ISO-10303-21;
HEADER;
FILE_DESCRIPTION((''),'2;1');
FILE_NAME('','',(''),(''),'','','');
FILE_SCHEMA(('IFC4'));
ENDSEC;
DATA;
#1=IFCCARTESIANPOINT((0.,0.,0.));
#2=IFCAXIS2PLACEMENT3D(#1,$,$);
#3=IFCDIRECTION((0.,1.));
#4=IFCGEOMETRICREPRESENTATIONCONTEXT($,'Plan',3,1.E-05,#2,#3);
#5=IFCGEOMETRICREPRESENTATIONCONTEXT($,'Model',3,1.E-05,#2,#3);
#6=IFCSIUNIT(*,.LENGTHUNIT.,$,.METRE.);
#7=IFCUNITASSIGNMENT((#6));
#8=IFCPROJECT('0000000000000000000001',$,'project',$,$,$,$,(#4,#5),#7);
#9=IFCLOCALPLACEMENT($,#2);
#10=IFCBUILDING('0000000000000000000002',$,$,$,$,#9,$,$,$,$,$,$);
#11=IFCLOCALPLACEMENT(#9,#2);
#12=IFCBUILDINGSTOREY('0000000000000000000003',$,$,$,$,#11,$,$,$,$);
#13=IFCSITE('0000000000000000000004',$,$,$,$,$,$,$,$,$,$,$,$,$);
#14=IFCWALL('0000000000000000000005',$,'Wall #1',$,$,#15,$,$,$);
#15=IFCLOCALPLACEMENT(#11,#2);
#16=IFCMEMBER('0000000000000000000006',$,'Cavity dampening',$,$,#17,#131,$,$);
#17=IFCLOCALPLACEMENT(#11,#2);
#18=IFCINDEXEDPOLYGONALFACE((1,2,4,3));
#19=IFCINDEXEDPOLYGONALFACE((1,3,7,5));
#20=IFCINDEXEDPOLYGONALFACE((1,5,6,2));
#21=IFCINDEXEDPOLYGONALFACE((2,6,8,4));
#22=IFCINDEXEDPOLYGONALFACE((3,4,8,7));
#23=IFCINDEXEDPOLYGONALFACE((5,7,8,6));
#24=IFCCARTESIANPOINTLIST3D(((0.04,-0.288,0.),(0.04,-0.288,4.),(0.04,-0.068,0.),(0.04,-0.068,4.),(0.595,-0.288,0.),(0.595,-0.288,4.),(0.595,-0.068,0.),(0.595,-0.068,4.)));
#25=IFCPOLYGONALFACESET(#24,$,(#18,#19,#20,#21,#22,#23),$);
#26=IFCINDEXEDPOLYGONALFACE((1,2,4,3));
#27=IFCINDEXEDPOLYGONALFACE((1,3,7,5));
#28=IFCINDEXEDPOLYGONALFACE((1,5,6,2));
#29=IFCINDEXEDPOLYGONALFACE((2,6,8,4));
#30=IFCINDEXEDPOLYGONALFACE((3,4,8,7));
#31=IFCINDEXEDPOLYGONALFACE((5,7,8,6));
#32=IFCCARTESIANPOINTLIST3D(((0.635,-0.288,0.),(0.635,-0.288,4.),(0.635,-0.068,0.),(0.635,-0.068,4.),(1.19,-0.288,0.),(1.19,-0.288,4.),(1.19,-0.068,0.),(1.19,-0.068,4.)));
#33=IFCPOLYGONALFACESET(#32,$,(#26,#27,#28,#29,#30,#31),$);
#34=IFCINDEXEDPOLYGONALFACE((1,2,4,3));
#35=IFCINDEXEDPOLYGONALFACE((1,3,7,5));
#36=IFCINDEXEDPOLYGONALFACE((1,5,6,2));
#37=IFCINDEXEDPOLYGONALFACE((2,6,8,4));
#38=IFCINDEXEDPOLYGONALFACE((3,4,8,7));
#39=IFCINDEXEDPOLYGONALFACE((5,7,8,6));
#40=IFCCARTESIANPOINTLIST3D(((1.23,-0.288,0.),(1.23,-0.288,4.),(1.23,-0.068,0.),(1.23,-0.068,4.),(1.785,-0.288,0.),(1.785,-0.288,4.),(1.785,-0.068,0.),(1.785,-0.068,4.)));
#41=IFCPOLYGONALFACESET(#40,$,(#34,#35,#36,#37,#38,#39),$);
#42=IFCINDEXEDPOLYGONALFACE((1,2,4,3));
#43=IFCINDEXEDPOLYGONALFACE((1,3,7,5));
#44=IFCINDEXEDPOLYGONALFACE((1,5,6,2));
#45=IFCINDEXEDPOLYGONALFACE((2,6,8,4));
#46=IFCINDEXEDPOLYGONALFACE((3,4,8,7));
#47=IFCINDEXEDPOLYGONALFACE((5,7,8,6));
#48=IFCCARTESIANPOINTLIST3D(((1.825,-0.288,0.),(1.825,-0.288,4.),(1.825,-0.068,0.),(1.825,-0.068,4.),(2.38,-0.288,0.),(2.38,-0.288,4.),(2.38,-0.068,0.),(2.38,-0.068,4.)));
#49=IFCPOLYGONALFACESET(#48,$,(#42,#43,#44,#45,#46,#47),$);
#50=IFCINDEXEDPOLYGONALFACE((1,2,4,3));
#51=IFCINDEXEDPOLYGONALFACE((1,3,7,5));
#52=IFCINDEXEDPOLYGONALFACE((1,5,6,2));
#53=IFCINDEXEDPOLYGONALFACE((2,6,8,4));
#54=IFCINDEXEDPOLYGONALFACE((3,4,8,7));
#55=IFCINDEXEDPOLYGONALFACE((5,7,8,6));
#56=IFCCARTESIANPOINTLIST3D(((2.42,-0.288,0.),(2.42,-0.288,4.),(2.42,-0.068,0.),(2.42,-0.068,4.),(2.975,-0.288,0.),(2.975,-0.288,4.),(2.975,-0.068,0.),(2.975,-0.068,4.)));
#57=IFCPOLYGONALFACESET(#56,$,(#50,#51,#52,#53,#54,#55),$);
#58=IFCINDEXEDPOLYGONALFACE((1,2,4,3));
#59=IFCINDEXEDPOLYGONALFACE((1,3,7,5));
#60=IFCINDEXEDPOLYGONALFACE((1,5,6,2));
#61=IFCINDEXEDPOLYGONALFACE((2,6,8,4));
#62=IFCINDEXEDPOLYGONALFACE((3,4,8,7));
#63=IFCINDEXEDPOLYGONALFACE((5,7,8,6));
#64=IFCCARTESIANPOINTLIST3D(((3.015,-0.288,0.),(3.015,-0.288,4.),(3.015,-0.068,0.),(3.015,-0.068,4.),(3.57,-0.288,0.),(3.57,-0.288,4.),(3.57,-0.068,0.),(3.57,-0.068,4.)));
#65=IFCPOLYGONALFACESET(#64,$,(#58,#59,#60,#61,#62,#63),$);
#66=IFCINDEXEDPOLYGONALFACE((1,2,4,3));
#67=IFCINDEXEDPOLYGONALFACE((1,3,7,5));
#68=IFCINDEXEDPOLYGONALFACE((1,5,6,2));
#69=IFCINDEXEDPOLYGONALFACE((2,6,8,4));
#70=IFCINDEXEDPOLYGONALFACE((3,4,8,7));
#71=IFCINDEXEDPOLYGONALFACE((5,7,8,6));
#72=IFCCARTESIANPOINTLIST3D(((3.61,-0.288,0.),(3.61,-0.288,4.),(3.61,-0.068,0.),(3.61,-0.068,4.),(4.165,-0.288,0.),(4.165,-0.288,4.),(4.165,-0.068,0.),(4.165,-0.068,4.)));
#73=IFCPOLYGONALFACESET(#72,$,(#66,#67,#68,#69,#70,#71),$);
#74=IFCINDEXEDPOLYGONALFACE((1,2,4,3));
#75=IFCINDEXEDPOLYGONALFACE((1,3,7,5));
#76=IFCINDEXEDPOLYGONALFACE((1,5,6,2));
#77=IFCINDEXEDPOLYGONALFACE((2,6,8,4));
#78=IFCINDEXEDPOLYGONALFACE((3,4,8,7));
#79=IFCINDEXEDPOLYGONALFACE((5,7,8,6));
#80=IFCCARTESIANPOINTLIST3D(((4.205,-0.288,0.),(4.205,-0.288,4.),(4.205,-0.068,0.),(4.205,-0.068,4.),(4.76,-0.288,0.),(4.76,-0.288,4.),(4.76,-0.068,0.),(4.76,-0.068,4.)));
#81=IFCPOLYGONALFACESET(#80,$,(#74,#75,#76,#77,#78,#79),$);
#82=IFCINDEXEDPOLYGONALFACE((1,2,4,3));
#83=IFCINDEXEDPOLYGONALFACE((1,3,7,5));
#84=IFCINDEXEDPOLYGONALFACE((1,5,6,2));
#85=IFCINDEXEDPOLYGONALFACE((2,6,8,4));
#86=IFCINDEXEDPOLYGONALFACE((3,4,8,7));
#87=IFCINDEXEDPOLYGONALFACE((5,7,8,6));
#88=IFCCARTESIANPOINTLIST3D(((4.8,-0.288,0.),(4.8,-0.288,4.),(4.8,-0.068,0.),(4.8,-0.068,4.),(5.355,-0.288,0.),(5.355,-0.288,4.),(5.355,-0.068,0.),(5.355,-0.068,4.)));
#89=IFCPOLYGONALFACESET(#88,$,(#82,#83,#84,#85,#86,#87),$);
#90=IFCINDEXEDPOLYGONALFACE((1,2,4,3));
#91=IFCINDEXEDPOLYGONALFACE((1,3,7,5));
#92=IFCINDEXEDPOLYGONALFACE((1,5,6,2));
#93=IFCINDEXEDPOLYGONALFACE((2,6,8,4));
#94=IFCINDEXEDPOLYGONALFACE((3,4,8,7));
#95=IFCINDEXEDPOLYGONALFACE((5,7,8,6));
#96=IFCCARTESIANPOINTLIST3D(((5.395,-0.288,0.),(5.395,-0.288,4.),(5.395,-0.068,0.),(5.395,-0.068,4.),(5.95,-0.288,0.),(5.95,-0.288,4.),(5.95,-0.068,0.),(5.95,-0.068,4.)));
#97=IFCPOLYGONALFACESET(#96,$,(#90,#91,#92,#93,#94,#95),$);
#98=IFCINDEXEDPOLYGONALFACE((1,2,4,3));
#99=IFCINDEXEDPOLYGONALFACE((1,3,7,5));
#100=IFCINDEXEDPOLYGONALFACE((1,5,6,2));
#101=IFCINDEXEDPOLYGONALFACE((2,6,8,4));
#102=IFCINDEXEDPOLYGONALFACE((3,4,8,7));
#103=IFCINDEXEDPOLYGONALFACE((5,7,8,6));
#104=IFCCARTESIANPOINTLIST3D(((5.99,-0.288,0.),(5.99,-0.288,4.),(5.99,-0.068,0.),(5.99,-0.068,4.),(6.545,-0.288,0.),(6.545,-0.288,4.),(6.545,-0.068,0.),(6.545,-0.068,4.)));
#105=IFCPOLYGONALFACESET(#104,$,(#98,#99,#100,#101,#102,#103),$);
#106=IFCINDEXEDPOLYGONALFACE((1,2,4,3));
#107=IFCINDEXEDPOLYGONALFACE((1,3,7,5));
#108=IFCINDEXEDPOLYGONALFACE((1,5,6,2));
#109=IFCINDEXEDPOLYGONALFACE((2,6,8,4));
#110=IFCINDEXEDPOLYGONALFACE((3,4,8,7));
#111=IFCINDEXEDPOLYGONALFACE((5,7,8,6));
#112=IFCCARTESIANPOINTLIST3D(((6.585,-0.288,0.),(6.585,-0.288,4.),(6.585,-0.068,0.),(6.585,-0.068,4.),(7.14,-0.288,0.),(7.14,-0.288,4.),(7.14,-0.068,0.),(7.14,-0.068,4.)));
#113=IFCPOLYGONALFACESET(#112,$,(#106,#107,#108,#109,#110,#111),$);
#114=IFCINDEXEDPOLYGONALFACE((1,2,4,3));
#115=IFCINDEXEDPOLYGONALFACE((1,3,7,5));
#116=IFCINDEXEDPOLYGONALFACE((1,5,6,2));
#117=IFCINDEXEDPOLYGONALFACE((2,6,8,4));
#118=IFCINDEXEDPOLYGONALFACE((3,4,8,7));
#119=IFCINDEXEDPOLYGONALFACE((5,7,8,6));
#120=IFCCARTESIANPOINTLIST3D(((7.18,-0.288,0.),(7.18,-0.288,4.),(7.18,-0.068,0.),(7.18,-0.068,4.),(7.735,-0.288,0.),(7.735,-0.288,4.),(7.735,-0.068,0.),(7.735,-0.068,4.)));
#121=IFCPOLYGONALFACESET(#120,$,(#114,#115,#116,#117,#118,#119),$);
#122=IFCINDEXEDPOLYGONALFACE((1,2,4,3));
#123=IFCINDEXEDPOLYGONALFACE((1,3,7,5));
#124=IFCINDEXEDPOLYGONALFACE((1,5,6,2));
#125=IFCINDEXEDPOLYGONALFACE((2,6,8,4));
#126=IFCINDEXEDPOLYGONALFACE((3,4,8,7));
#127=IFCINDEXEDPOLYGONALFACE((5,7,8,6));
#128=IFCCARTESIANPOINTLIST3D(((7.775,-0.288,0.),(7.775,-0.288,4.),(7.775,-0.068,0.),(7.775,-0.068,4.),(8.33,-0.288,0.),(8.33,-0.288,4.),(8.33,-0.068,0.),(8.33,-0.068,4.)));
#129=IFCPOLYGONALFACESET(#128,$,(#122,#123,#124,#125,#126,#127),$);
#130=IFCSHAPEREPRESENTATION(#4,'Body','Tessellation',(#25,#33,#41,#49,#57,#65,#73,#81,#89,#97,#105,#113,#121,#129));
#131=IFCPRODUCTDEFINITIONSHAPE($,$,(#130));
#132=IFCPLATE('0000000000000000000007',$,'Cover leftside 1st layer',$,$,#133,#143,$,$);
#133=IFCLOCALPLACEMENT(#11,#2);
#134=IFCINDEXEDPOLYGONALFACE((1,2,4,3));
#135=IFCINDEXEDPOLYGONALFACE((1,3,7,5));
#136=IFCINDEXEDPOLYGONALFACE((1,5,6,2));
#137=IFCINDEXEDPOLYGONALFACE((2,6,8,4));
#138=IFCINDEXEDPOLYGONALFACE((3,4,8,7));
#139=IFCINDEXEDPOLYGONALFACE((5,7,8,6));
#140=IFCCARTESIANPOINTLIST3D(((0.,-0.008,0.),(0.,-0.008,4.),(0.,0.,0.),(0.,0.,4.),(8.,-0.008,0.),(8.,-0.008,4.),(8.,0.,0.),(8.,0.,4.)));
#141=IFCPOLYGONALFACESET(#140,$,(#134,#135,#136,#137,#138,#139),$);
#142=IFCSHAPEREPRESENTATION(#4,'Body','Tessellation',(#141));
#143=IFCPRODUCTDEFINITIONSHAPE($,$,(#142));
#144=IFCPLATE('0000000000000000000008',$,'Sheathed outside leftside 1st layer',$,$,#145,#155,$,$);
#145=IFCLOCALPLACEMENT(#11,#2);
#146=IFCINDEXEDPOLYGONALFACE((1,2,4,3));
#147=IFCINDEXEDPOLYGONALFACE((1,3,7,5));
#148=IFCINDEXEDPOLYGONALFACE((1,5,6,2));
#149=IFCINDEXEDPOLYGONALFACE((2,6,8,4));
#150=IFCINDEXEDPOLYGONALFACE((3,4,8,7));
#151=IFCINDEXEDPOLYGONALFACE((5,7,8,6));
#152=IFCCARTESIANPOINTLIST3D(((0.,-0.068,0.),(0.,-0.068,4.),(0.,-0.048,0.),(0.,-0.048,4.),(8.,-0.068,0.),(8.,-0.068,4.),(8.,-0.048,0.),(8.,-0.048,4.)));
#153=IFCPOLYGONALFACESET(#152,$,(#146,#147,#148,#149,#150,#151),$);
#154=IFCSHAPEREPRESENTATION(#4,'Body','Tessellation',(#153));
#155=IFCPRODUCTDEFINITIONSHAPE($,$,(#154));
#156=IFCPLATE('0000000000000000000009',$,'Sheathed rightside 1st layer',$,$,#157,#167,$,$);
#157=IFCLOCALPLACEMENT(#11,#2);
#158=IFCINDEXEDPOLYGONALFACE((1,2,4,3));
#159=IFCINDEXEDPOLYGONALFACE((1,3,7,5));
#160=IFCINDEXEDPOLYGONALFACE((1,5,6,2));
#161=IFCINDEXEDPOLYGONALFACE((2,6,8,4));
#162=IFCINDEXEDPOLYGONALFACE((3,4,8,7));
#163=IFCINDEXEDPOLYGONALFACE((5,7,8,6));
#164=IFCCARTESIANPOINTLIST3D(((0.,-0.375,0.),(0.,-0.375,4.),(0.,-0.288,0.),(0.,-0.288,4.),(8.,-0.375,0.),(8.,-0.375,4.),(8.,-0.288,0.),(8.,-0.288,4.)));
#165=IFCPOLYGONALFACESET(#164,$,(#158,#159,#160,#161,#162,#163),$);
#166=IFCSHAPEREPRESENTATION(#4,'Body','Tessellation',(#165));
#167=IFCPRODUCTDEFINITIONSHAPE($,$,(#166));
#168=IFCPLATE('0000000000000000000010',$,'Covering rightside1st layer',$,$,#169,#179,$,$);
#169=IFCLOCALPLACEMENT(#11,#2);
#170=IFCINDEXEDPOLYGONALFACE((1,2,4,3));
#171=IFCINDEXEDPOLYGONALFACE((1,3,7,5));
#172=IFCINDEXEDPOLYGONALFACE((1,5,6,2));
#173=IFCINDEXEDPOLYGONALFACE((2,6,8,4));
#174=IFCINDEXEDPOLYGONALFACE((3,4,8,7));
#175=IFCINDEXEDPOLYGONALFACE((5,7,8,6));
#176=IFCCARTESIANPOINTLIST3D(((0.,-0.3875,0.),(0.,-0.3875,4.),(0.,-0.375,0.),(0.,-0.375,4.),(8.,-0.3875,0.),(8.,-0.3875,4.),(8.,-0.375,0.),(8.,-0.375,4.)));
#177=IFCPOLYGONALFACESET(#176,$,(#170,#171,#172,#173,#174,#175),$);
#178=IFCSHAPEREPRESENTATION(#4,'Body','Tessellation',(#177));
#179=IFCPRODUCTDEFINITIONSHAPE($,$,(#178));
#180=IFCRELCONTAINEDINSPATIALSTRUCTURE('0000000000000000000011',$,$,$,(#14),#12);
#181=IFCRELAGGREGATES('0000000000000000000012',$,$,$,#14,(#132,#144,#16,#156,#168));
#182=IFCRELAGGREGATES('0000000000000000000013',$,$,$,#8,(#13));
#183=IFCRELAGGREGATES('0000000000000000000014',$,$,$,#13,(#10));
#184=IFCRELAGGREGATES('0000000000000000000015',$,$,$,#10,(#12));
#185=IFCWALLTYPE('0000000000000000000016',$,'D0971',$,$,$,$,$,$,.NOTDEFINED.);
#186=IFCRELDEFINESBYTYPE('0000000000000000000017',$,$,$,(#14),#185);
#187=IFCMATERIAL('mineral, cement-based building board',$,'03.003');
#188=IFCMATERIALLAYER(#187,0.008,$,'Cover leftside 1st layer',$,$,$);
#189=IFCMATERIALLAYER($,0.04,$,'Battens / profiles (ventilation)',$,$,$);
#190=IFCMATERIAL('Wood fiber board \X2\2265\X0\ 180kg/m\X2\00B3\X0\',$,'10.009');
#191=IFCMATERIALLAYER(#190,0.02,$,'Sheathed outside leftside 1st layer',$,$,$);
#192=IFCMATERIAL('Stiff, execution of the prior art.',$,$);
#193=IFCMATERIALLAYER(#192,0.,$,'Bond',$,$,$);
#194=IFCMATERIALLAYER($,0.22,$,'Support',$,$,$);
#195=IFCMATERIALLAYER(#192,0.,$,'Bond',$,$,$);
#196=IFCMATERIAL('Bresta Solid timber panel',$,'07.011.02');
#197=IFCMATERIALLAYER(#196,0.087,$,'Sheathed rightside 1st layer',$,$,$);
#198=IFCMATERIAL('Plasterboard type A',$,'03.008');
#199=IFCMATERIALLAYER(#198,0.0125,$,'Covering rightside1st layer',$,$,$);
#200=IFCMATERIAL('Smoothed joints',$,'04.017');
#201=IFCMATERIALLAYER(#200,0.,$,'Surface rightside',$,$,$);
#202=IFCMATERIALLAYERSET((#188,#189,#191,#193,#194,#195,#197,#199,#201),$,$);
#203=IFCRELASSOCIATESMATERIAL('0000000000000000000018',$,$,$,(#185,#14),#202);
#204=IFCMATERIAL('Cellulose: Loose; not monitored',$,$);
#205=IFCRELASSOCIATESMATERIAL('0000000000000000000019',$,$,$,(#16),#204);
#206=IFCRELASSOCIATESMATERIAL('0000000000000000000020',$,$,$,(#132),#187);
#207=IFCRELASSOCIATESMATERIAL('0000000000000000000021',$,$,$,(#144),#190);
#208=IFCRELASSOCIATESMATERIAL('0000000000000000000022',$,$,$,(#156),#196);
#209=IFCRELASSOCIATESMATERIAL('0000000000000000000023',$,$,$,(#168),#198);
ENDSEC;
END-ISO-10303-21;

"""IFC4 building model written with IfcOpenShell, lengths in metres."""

from ifc_helpers import new_model, si_unit, direction, frame, frame_2d, origin, origin_with_axes, place, context, project, spatial, rectangle, extrude, material, layer, layer_set, type_object, element, aggregate, save


model = new_model("IFC4")

# Units and contexts
plan_context = context("Plan", 3, precision=1e-05, world=origin(), true_north=direction((0.0, 1.0)))
model_context = context("Model", 3, precision=1e-05, world=origin(), true_north=direction((0.0, 1.0)))
ifc_project = project(units=[si_unit("LENGTHUNIT", "METRE")], contexts=[plan_context, model_context])

# Site, building, storey
site = spatial("IfcSite", under=ifc_project)
building_placement = place(None, origin())
building = spatial("IfcBuilding", under=site, at=building_placement)
storey_placement = place(building_placement, origin())
storey = spatial("IfcBuildingStorey", under=building, at=storey_placement)

# Wall, member, plates
ifc_material_1 = material(Name="mineral, cement-based building board", Category="03.003")
ifc_layer_1 = layer(ifc_material_1, 0.008, Name="Cover leftside 1st layer")
ifc_layer_2 = layer(None, 0.04, Name="Battens / profiles (ventilation)")
ifc_material_2 = material(Name="Wood fiber board ≥ 180kg/m³", Category="10.009")
ifc_layer_3 = layer(ifc_material_2, 0.02, Name="Sheathed outside leftside 1st layer")
ifc_material_3 = material(Name="Stiff, execution of the prior art.")
ifc_layer_4 = layer(ifc_material_3, 0.0, Name="Bond")
ifc_layer_5 = layer(None, 0.22, Name="Support")
ifc_layer_6 = layer(ifc_material_3, 0.0, Name="Bond")
ifc_material_4 = material(Name="Bresta Solid timber panel", Category="07.011.02")
ifc_layer_7 = layer(ifc_material_4, 0.087, Name="Sheathed rightside 1st layer")
ifc_material_5 = material(Name="Plasterboard type A", Category="03.008")
ifc_layer_8 = layer(ifc_material_5, 0.0125, Name="Covering rightside1st layer")
ifc_material_6 = material(Name="Smoothed joints", Category="04.017")
ifc_layer_9 = layer(ifc_material_6, 0.0, Name="Surface rightside")
ifc_layer_set = layer_set([ifc_layer_1, ifc_layer_2, ifc_layer_3, ifc_layer_4, ifc_layer_5, ifc_layer_6, ifc_layer_7, ifc_layer_8, ifc_layer_9])
wall_type = type_object("IfcWallType", Name="D0971", PredefinedType="NOTDEFINED", material=ifc_layer_set)
wall_placement = place(None, frame((0.0, 0.0, 0.0), z_axis=(0.0, -1.0, 0.0), x_axis=(1.0, 0.0, 0.0)))
wall = element("IfcWall", 1, at=wall_placement, inside=storey, type_object=wall_type, material=ifc_layer_set, Name="Wall #1")
ifc_material_7 = material(Name="Cellulose: Loose; not monitored")
member_1_placement = place(wall_placement, origin())
member_1 = element("IfcMember", 2, at=member_1_placement, material=ifc_material_7, Name="Cavity dampening", context=plan_context, shape_type="SweptSolid", body=[
    extrude(rectangle(XDim=0.555, YDim=0.22, at=frame_2d((0.2775, 0.11), x_axis=(1.0, 0.0))), frame((0.04, 4.0, 0.068), z_axis=(0.0, -1.0, 0.0), x_axis=(1.0, 0.0, 0.0)), (0.0, 0.0, 1.0), 4.0),
    extrude(rectangle(XDim=0.555, YDim=0.22, at=frame_2d((0.2775, 0.11), x_axis=(1.0, 0.0))), frame((0.635, 4.0, 0.068), z_axis=(0.0, -1.0, 0.0), x_axis=(1.0, 0.0, 0.0)), (0.0, 0.0, 1.0), 4.0),
    extrude(rectangle(XDim=0.555, YDim=0.22, at=frame_2d((0.2775, 0.11), x_axis=(1.0, 0.0))), frame((1.23, 4.0, 0.068), z_axis=(0.0, -1.0, 0.0), x_axis=(1.0, 0.0, 0.0)), (0.0, 0.0, 1.0), 4.0),
    extrude(rectangle(XDim=0.555, YDim=0.22, at=frame_2d((0.2775, 0.11), x_axis=(1.0, 0.0))), frame((1.825, 4.0, 0.068), z_axis=(0.0, -1.0, 0.0), x_axis=(1.0, 0.0, 0.0)), (0.0, 0.0, 1.0), 4.0),
    extrude(rectangle(XDim=0.555, YDim=0.22, at=frame_2d((0.2775, 0.11), x_axis=(1.0, 0.0))), frame((2.42, 4.0, 0.068), z_axis=(0.0, -1.0, 0.0), x_axis=(1.0, 0.0, 0.0)), (0.0, 0.0, 1.0), 4.0),
    extrude(rectangle(XDim=0.555, YDim=0.22, at=frame_2d((0.2775, 0.11), x_axis=(1.0, 0.0))), frame((3.015, 4.0, 0.068), z_axis=(0.0, -1.0, 0.0), x_axis=(1.0, 0.0, 0.0)), (0.0, 0.0, 1.0), 4.0),
    extrude(rectangle(XDim=0.555, YDim=0.22, at=frame_2d((0.2775, 0.11), x_axis=(1.0, 0.0))), frame((3.61, 4.0, 0.068), z_axis=(0.0, -1.0, 0.0), x_axis=(1.0, 0.0, 0.0)), (0.0, 0.0, 1.0), 4.0),
    extrude(rectangle(XDim=0.555, YDim=0.22, at=frame_2d((0.2775, 0.11), x_axis=(1.0, 0.0))), frame((4.205, 4.0, 0.068), z_axis=(0.0, -1.0, 0.0), x_axis=(1.0, 0.0, 0.0)), (0.0, 0.0, 1.0), 4.0),
    extrude(rectangle(XDim=0.555, YDim=0.22, at=frame_2d((0.2775, 0.11), x_axis=(1.0, 0.0))), frame((4.8, 4.0, 0.068), z_axis=(0.0, -1.0, 0.0), x_axis=(1.0, 0.0, 0.0)), (0.0, 0.0, 1.0), 4.0),
    extrude(rectangle(XDim=0.555, YDim=0.22, at=frame_2d((0.2775, 0.11), x_axis=(1.0, 0.0))), frame((5.395, 4.0, 0.068), z_axis=(0.0, -1.0, 0.0), x_axis=(1.0, 0.0, 0.0)), (0.0, 0.0, 1.0), 4.0),
    extrude(rectangle(XDim=0.555, YDim=0.22, at=frame_2d((0.2775, 0.11), x_axis=(1.0, 0.0))), frame((5.99, 4.0, 0.068), z_axis=(0.0, -1.0, 0.0), x_axis=(1.0, 0.0, 0.0)), (0.0, 0.0, 1.0), 4.0),
    extrude(rectangle(XDim=0.555, YDim=0.22, at=frame_2d((0.2775, 0.11), x_axis=(1.0, 0.0))), frame((6.585, 4.0, 0.068), z_axis=(0.0, -1.0, 0.0), x_axis=(1.0, 0.0, 0.0)), (0.0, 0.0, 1.0), 4.0),
    extrude(rectangle(XDim=0.555, YDim=0.22, at=frame_2d((0.2775, 0.11), x_axis=(1.0, 0.0))), frame((7.18, 4.0, 0.068), z_axis=(0.0, -1.0, 0.0), x_axis=(1.0, 0.0, 0.0)), (0.0, 0.0, 1.0), 4.0),
    extrude(rectangle(XDim=0.555, YDim=0.22, at=frame_2d((0.2775, 0.11), x_axis=(1.0, 0.0))), frame((7.775, 4.0, 0.068), z_axis=(0.0, -1.0, 0.0), x_axis=(1.0, 0.0, 0.0)), (0.0, 0.0, 1.0), 4.0),
])
plate_1_placement = place(wall_placement, origin())
plate_1 = element("IfcPlate", 3, at=plate_1_placement, material=ifc_material_1, Name="Cover leftside 1st layer", context=plan_context, shape_type="SweptSolid", body=[
    extrude(rectangle(XDim=8.0, YDim=4.0, at=frame_2d((4.0, 2.0), x_axis=(1.0, 0.0))), origin_with_axes(), (0.0, 0.0, 1.0), 0.008),
])
plate_2_placement = place(wall_placement, origin())
plate_2 = element("IfcPlate", 4, at=plate_2_placement, material=ifc_material_2, Name="Sheathed outside leftside 1st layer", context=plan_context, shape_type="SweptSolid", body=[
    extrude(rectangle(XDim=8.0, YDim=4.0, at=frame_2d((4.0, 2.0), x_axis=(1.0, 0.0))), frame((0.0, 0.0, 0.048), z_axis=(0.0, 0.0, 1.0), x_axis=(1.0, 0.0, 0.0)), (0.0, 0.0, 1.0), 0.02),
])
plate_3_placement = place(wall_placement, origin())
plate_3 = element("IfcPlate", 5, at=plate_3_placement, material=ifc_material_4, Name="Sheathed rightside 1st layer", context=plan_context, shape_type="SweptSolid", body=[
    extrude(rectangle(XDim=8.0, YDim=4.0, at=frame_2d((4.0, 2.0), x_axis=(1.0, 0.0))), frame((0.0, 0.0, 0.288), z_axis=(0.0, 0.0, 1.0), x_axis=(1.0, 0.0, 0.0)), (0.0, 0.0, 1.0), 0.087),
])
plate_4_placement = place(wall_placement, origin())
plate_4 = element("IfcPlate", 6, at=plate_4_placement, material=ifc_material_5, Name="Covering rightside1st layer", context=plan_context, shape_type="SweptSolid", body=[
    extrude(rectangle(XDim=8.0, YDim=4.0, at=frame_2d((4.0, 2.0), x_axis=(1.0, 0.0))), frame((0.0, 0.0, 0.375), z_axis=(0.0, 0.0, 1.0), x_axis=(1.0, 0.0, 0.0)), (0.0, 0.0, 1.0), 0.0125),
])
aggregate(wall, [plate_1, plate_2, member_1, plate_3, plate_4])

save(model, "model.ifc")
